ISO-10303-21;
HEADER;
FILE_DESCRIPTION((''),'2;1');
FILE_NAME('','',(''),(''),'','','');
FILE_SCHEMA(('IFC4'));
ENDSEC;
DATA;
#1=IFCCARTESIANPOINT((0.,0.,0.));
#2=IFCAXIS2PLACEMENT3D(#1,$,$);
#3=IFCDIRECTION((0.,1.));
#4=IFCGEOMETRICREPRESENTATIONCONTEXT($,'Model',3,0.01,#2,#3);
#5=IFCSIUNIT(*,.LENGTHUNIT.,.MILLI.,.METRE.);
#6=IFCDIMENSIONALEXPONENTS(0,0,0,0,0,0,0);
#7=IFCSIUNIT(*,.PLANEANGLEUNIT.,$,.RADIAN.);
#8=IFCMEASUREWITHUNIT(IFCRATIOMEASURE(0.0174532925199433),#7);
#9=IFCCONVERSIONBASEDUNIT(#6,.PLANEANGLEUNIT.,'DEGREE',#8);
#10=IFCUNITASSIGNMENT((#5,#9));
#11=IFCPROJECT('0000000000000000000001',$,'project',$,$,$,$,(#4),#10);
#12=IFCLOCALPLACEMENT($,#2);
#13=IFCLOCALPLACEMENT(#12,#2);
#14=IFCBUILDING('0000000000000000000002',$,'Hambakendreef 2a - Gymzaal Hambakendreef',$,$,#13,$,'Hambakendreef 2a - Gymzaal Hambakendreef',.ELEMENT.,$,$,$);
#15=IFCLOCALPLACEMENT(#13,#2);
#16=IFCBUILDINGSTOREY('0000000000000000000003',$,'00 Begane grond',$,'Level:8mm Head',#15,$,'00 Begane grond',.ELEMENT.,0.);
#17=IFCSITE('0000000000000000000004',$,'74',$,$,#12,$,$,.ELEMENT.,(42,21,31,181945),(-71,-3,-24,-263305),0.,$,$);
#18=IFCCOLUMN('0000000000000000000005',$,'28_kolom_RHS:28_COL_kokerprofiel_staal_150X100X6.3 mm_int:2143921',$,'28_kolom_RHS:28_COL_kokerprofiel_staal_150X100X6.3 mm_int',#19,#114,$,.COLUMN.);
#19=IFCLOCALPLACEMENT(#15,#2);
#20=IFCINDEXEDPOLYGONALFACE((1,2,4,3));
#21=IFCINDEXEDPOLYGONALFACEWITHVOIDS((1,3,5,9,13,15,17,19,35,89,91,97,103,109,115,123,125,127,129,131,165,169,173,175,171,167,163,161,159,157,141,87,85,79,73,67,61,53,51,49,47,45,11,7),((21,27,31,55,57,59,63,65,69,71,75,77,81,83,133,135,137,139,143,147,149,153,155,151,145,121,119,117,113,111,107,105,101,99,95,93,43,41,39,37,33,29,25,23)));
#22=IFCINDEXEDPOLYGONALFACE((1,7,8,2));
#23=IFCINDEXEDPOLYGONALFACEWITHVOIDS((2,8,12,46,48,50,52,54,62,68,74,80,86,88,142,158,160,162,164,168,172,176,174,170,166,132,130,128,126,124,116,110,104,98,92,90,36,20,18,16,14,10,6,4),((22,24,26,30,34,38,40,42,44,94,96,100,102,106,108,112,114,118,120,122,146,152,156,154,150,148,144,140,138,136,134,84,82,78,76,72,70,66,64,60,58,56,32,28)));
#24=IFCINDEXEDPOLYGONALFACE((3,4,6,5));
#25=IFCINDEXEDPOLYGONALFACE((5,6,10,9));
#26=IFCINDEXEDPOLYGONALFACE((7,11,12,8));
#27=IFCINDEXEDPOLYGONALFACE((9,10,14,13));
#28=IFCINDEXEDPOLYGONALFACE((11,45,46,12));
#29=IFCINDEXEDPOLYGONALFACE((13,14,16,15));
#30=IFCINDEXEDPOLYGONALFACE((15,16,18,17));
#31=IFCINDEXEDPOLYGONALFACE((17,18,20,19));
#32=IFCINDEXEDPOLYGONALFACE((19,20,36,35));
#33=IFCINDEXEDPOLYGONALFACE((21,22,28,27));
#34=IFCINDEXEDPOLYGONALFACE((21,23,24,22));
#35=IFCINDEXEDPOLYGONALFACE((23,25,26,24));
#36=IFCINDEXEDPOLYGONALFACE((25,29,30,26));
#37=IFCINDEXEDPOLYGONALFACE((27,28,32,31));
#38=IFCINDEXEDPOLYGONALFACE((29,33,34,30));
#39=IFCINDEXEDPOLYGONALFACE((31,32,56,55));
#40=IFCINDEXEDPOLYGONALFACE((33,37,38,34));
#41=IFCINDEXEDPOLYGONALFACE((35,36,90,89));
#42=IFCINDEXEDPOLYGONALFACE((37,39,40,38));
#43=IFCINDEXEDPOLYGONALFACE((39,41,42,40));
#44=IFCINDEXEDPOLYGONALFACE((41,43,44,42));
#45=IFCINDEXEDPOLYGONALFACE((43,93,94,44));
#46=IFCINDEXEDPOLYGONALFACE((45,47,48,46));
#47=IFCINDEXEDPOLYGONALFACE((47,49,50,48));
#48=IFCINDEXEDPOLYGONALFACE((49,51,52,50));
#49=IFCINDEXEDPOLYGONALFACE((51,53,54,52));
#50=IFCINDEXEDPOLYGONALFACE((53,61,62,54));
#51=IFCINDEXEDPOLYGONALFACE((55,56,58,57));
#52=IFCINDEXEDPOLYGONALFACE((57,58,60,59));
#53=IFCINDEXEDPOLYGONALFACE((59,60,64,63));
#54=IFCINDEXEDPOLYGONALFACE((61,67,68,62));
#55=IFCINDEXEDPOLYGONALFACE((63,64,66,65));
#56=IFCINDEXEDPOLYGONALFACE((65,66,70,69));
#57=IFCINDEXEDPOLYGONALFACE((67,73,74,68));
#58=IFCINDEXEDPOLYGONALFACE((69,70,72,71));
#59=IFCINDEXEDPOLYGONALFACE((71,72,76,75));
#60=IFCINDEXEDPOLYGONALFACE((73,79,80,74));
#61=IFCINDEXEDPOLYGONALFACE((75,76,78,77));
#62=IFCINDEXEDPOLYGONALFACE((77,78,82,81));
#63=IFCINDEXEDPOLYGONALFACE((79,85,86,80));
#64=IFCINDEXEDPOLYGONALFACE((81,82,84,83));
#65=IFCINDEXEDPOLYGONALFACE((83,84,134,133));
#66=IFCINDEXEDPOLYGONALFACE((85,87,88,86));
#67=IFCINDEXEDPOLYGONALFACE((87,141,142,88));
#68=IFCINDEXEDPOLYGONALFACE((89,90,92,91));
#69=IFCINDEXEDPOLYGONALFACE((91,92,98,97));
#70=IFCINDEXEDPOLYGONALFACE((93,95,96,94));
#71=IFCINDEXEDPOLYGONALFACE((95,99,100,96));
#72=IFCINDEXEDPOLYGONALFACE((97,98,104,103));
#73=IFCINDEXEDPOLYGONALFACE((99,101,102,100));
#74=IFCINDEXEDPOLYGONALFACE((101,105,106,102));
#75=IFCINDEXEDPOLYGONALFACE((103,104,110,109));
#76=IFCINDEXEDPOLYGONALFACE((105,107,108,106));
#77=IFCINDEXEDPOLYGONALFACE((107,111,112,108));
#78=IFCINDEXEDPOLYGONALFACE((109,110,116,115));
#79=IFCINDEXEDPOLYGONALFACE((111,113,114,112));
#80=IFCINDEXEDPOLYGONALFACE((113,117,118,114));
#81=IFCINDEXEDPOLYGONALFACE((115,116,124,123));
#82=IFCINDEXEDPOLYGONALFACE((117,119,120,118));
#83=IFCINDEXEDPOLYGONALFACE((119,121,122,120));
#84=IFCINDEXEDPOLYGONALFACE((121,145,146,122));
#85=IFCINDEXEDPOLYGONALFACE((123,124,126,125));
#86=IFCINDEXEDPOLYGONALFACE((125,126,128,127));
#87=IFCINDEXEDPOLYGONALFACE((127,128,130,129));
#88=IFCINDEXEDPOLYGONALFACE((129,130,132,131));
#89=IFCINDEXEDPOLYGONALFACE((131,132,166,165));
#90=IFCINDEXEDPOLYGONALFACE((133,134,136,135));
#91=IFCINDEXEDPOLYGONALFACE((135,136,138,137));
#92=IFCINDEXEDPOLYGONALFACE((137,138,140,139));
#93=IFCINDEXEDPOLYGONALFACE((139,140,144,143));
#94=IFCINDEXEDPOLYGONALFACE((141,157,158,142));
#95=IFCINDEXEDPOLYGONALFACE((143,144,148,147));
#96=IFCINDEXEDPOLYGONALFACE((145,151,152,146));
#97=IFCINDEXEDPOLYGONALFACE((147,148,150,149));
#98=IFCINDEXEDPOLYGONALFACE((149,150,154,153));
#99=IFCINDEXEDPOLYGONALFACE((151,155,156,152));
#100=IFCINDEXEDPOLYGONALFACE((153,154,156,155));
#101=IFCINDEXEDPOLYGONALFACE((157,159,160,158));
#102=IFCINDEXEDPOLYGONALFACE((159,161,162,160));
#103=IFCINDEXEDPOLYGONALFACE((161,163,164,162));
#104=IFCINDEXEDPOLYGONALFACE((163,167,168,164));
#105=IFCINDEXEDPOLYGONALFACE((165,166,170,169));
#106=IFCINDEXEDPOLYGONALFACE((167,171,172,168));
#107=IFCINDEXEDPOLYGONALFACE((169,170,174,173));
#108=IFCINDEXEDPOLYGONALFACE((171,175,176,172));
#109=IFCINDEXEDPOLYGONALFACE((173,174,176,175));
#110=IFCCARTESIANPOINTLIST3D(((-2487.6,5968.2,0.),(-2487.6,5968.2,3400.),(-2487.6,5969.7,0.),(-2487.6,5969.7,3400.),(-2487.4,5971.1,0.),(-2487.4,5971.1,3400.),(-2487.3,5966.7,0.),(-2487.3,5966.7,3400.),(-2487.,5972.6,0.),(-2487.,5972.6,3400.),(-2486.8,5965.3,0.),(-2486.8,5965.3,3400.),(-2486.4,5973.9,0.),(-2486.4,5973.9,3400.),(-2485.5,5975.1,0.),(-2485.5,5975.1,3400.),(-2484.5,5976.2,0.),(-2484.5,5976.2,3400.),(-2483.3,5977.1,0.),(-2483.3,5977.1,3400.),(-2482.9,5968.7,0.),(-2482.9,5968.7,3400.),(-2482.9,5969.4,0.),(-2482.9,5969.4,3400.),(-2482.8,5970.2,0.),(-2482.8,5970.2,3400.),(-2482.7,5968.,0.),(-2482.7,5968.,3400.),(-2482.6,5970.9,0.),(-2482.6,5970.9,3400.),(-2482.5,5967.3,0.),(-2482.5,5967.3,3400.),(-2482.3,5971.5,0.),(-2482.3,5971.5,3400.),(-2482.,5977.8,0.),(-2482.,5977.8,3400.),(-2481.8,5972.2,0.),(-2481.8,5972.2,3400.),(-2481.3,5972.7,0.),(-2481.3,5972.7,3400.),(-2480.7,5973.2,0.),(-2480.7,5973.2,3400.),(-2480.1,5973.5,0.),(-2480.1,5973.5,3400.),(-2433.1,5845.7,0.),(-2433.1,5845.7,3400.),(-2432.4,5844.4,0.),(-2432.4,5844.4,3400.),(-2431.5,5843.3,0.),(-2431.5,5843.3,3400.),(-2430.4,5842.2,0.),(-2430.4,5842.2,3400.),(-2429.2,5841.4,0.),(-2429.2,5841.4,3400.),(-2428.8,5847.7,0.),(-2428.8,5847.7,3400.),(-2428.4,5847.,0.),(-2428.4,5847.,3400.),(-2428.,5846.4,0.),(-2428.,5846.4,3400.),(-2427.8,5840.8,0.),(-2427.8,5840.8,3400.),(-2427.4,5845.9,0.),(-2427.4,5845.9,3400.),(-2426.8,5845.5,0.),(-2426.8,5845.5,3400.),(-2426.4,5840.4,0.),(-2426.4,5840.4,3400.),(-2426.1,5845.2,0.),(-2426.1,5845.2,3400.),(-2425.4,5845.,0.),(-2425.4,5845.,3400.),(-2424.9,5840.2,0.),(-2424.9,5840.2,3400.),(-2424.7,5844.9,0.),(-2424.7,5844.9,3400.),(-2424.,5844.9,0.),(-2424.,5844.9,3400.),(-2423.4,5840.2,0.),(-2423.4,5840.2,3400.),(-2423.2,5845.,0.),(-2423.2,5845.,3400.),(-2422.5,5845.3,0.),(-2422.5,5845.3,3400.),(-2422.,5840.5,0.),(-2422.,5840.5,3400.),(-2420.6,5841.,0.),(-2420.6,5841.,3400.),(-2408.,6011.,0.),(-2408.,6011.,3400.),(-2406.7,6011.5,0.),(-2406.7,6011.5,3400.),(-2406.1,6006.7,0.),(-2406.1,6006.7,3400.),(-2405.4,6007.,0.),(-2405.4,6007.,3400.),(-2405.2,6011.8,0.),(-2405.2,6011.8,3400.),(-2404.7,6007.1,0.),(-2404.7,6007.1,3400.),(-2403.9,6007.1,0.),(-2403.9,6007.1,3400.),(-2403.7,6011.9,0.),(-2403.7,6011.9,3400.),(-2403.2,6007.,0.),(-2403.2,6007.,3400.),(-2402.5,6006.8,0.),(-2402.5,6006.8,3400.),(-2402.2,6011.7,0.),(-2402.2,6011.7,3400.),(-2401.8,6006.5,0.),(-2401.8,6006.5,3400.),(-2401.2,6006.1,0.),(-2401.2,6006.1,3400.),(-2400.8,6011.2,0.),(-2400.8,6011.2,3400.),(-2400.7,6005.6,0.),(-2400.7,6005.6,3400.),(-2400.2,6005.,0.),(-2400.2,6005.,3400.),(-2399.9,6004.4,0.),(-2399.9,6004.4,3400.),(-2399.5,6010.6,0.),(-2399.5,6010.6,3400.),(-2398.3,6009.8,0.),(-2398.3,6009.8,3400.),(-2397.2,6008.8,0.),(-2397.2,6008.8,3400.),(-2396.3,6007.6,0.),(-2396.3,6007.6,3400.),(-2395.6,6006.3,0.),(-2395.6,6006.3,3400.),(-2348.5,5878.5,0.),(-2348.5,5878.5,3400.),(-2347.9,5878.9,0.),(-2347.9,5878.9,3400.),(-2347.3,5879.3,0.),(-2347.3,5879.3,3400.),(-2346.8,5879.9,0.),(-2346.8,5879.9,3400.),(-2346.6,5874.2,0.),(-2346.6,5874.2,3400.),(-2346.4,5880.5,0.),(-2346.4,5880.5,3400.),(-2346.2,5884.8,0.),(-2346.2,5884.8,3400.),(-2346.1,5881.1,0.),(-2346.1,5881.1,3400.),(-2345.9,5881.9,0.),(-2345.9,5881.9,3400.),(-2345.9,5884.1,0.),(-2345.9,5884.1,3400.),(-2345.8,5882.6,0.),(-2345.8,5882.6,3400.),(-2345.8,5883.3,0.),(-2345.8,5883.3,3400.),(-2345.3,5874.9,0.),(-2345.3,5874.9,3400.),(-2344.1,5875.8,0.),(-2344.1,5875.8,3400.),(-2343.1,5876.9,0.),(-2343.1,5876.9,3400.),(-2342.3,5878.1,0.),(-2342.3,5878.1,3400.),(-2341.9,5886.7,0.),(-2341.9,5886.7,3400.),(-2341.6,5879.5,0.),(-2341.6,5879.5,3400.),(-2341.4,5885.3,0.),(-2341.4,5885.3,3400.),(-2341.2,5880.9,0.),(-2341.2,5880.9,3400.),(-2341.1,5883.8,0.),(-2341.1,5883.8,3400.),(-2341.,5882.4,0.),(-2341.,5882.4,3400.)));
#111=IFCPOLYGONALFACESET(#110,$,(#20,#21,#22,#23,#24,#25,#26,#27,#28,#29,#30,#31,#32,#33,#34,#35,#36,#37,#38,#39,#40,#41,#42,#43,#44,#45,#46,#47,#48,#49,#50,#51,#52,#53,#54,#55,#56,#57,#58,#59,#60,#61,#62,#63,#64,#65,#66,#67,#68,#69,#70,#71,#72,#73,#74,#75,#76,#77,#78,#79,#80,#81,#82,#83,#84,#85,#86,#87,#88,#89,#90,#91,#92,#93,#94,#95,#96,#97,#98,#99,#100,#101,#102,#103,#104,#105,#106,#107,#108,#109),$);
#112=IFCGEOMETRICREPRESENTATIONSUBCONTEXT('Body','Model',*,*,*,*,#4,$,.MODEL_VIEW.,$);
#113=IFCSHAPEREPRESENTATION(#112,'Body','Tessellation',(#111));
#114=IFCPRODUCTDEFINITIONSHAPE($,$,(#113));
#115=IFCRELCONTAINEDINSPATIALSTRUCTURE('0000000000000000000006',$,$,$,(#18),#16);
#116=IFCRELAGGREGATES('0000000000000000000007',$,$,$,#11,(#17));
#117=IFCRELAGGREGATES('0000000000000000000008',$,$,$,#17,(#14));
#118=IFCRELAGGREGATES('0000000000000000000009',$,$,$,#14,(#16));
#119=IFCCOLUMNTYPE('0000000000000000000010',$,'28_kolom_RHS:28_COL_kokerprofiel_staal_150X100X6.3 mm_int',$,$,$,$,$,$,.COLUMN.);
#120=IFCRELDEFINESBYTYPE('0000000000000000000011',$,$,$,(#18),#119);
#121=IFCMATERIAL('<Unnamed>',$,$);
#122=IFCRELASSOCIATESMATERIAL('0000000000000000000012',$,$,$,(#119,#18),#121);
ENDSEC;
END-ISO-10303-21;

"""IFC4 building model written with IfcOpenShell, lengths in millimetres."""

from ifc_helpers import new_model, entity, si_unit, converted_unit, direction, frame, origin, place, context, subcontext, project, spatial, indexed_curve, outline, extrude, source, transform, mapped, material, type_object, type_shapes, element, save


model = new_model("IFC4")

# Units and contexts
model_context = context("Model", 3, precision=0.01, world=origin(), true_north=direction((0.0, 1.0)))
body_context = subcontext(model_context, "Body", "Model", "MODEL_VIEW")
ifc_project = project(units=[si_unit("LENGTHUNIT", "METRE", prefix="MILLI"), converted_unit("PLANEANGLEUNIT", "DEGREE", entity("IfcRatioMeasure", 0.0174532925199433), si_unit("PLANEANGLEUNIT", "RADIAN"), dimensions=[0, 0, 0, 0, 0, 0, 0])], contexts=[model_context])

# Site, building, storey
site_placement = place(None, origin())
site = spatial("IfcSite", under=ifc_project, at=site_placement, Name="74", CompositionType="ELEMENT", RefLatitude=(42, 21, 31, 181945), RefLongitude=(-71, -3, -24, -263305), RefElevation=0.0)
building_placement = place(site_placement, origin())
building = spatial("IfcBuilding", under=site, at=building_placement, Name="Hambakendreef 2a - Gymzaal Hambakendreef", LongName="Hambakendreef 2a - Gymzaal Hambakendreef", CompositionType="ELEMENT")
storey_placement = place(building_placement, origin())
storey = spatial("IfcBuildingStorey", under=building, at=storey_placement, Name="00 Begane grond", ObjectType="Level:8mm Head", LongName="00 Begane grond", CompositionType="ELEMENT", Elevation=0.0)

# Column
ifc_material_1 = material(Name="<Unnamed>")
column_type = type_object("IfcColumnType", Name="28_kolom_RHS:28_COL_kokerprofiel_staal_150X100X6.3 mm_int", PredefinedType="COLUMN", material=ifc_material_1)
shared_shape_1 = source(origin(), body_context, "Body", "SweptSolid", [
    extrude(outline(indexed_curve([(-40.5, -75.0), (40.5, -75.0), (42.0, -74.9), (43.5, -74.5), (44.8, -74.0), (46.1, -73.2), (47.2, -72.2), (48.2, -71.1), (49.0, -69.8), (49.5, -68.5), (49.9, -67.0), (50.0, -65.6), (50.0, 65.6), (49.9, 67.0), (49.5, 68.5), (49.0, 69.8), (48.2, 71.1), (47.2, 72.2), (46.1, 73.2), (44.8, 74.0), (43.5, 74.5), (42.0, 74.9), (40.5, 75.0), (-40.5, 75.0), (-42.0, 74.9), (-43.5, 74.5), (-44.8, 74.0), (-46.1, 73.2), (-47.2, 72.2), (-48.2, 71.1), (-49.0, 69.8), (-49.5, 68.5), (-49.9, 67.0), (-50.0, 65.6), (-50.0, -65.6), (-49.9, -67.0), (-49.5, -68.5), (-49.0, -69.8), (-48.2, -71.1), (-47.2, -72.2), (-46.1, -73.2), (-44.8, -74.0), (-43.5, -74.5), (-42.0, -74.9), (-40.5, -75.0)], self_intersect=False), holes=[indexed_curve([(-45.3, 65.5), (-45.2, 66.3), (-45.0, 67.0), (-44.8, 67.7), (-44.4, 68.3), (-43.9, 68.9), (-43.3, 69.4), (-42.7, 69.8), (-42.0, 70.0), (-41.3, 70.2), (-40.6, 70.3), (40.5, 70.3), (41.3, 70.2), (42.0, 70.0), (42.7, 69.8), (43.3, 69.4), (43.9, 68.9), (44.4, 68.3), (44.8, 67.7), (45.0, 67.0), (45.2, 66.3), (45.3, 65.5), (45.3, -65.5), (45.2, -66.3), (45.0, -67.0), (44.8, -67.7), (44.4, -68.3), (43.9, -68.9), (43.3, -69.4), (42.7, -69.8), (42.0, -70.0), (41.3, -70.2), (40.5, -70.3), (-40.6, -70.3), (-41.3, -70.2), (-42.0, -70.0), (-42.7, -69.8), (-43.3, -69.4), (-43.9, -68.9), (-44.4, -68.3), (-44.8, -67.7), (-45.0, -67.0), (-45.2, -66.3), (-45.3, -65.5), (-45.3, 65.5)], self_intersect=False)]), frame((235.6, 34.3, 0.0), z_axis=(0.0, 0.0, 1.0), x_axis=(0.0, 1.0, 0.0)), (0.0, 0.0, 1.0), 3400.0),
])
type_shapes(column_type, [shared_shape_1])
for number, where, z_axis, x_axis, name in (
    (1, (-2542.1, 6126.9, 0.0), (0.0, 0.0, 1.0), (0.40959, -0.91227, 0.0), "28_kolom_RHS:28_COL_kokerprofiel_staal_150X100X6.3 mm_int:2143921"),
):
    element("IfcColumn", number, at=place(storey_placement, frame(where, z_axis=z_axis, x_axis=x_axis)), inside=storey, type_object=column_type, material=ifc_material_1, Name=name, ObjectType="28_kolom_RHS:28_COL_kokerprofiel_staal_150X100X6.3 mm_int", PredefinedType="COLUMN", context=body_context, shape_type="MappedRepresentation", body=[
        mapped(shared_shape_1, transform((0.0, 0.0, 0.0), scale=1.0)),
    ])

save(model, "model.ifc")
